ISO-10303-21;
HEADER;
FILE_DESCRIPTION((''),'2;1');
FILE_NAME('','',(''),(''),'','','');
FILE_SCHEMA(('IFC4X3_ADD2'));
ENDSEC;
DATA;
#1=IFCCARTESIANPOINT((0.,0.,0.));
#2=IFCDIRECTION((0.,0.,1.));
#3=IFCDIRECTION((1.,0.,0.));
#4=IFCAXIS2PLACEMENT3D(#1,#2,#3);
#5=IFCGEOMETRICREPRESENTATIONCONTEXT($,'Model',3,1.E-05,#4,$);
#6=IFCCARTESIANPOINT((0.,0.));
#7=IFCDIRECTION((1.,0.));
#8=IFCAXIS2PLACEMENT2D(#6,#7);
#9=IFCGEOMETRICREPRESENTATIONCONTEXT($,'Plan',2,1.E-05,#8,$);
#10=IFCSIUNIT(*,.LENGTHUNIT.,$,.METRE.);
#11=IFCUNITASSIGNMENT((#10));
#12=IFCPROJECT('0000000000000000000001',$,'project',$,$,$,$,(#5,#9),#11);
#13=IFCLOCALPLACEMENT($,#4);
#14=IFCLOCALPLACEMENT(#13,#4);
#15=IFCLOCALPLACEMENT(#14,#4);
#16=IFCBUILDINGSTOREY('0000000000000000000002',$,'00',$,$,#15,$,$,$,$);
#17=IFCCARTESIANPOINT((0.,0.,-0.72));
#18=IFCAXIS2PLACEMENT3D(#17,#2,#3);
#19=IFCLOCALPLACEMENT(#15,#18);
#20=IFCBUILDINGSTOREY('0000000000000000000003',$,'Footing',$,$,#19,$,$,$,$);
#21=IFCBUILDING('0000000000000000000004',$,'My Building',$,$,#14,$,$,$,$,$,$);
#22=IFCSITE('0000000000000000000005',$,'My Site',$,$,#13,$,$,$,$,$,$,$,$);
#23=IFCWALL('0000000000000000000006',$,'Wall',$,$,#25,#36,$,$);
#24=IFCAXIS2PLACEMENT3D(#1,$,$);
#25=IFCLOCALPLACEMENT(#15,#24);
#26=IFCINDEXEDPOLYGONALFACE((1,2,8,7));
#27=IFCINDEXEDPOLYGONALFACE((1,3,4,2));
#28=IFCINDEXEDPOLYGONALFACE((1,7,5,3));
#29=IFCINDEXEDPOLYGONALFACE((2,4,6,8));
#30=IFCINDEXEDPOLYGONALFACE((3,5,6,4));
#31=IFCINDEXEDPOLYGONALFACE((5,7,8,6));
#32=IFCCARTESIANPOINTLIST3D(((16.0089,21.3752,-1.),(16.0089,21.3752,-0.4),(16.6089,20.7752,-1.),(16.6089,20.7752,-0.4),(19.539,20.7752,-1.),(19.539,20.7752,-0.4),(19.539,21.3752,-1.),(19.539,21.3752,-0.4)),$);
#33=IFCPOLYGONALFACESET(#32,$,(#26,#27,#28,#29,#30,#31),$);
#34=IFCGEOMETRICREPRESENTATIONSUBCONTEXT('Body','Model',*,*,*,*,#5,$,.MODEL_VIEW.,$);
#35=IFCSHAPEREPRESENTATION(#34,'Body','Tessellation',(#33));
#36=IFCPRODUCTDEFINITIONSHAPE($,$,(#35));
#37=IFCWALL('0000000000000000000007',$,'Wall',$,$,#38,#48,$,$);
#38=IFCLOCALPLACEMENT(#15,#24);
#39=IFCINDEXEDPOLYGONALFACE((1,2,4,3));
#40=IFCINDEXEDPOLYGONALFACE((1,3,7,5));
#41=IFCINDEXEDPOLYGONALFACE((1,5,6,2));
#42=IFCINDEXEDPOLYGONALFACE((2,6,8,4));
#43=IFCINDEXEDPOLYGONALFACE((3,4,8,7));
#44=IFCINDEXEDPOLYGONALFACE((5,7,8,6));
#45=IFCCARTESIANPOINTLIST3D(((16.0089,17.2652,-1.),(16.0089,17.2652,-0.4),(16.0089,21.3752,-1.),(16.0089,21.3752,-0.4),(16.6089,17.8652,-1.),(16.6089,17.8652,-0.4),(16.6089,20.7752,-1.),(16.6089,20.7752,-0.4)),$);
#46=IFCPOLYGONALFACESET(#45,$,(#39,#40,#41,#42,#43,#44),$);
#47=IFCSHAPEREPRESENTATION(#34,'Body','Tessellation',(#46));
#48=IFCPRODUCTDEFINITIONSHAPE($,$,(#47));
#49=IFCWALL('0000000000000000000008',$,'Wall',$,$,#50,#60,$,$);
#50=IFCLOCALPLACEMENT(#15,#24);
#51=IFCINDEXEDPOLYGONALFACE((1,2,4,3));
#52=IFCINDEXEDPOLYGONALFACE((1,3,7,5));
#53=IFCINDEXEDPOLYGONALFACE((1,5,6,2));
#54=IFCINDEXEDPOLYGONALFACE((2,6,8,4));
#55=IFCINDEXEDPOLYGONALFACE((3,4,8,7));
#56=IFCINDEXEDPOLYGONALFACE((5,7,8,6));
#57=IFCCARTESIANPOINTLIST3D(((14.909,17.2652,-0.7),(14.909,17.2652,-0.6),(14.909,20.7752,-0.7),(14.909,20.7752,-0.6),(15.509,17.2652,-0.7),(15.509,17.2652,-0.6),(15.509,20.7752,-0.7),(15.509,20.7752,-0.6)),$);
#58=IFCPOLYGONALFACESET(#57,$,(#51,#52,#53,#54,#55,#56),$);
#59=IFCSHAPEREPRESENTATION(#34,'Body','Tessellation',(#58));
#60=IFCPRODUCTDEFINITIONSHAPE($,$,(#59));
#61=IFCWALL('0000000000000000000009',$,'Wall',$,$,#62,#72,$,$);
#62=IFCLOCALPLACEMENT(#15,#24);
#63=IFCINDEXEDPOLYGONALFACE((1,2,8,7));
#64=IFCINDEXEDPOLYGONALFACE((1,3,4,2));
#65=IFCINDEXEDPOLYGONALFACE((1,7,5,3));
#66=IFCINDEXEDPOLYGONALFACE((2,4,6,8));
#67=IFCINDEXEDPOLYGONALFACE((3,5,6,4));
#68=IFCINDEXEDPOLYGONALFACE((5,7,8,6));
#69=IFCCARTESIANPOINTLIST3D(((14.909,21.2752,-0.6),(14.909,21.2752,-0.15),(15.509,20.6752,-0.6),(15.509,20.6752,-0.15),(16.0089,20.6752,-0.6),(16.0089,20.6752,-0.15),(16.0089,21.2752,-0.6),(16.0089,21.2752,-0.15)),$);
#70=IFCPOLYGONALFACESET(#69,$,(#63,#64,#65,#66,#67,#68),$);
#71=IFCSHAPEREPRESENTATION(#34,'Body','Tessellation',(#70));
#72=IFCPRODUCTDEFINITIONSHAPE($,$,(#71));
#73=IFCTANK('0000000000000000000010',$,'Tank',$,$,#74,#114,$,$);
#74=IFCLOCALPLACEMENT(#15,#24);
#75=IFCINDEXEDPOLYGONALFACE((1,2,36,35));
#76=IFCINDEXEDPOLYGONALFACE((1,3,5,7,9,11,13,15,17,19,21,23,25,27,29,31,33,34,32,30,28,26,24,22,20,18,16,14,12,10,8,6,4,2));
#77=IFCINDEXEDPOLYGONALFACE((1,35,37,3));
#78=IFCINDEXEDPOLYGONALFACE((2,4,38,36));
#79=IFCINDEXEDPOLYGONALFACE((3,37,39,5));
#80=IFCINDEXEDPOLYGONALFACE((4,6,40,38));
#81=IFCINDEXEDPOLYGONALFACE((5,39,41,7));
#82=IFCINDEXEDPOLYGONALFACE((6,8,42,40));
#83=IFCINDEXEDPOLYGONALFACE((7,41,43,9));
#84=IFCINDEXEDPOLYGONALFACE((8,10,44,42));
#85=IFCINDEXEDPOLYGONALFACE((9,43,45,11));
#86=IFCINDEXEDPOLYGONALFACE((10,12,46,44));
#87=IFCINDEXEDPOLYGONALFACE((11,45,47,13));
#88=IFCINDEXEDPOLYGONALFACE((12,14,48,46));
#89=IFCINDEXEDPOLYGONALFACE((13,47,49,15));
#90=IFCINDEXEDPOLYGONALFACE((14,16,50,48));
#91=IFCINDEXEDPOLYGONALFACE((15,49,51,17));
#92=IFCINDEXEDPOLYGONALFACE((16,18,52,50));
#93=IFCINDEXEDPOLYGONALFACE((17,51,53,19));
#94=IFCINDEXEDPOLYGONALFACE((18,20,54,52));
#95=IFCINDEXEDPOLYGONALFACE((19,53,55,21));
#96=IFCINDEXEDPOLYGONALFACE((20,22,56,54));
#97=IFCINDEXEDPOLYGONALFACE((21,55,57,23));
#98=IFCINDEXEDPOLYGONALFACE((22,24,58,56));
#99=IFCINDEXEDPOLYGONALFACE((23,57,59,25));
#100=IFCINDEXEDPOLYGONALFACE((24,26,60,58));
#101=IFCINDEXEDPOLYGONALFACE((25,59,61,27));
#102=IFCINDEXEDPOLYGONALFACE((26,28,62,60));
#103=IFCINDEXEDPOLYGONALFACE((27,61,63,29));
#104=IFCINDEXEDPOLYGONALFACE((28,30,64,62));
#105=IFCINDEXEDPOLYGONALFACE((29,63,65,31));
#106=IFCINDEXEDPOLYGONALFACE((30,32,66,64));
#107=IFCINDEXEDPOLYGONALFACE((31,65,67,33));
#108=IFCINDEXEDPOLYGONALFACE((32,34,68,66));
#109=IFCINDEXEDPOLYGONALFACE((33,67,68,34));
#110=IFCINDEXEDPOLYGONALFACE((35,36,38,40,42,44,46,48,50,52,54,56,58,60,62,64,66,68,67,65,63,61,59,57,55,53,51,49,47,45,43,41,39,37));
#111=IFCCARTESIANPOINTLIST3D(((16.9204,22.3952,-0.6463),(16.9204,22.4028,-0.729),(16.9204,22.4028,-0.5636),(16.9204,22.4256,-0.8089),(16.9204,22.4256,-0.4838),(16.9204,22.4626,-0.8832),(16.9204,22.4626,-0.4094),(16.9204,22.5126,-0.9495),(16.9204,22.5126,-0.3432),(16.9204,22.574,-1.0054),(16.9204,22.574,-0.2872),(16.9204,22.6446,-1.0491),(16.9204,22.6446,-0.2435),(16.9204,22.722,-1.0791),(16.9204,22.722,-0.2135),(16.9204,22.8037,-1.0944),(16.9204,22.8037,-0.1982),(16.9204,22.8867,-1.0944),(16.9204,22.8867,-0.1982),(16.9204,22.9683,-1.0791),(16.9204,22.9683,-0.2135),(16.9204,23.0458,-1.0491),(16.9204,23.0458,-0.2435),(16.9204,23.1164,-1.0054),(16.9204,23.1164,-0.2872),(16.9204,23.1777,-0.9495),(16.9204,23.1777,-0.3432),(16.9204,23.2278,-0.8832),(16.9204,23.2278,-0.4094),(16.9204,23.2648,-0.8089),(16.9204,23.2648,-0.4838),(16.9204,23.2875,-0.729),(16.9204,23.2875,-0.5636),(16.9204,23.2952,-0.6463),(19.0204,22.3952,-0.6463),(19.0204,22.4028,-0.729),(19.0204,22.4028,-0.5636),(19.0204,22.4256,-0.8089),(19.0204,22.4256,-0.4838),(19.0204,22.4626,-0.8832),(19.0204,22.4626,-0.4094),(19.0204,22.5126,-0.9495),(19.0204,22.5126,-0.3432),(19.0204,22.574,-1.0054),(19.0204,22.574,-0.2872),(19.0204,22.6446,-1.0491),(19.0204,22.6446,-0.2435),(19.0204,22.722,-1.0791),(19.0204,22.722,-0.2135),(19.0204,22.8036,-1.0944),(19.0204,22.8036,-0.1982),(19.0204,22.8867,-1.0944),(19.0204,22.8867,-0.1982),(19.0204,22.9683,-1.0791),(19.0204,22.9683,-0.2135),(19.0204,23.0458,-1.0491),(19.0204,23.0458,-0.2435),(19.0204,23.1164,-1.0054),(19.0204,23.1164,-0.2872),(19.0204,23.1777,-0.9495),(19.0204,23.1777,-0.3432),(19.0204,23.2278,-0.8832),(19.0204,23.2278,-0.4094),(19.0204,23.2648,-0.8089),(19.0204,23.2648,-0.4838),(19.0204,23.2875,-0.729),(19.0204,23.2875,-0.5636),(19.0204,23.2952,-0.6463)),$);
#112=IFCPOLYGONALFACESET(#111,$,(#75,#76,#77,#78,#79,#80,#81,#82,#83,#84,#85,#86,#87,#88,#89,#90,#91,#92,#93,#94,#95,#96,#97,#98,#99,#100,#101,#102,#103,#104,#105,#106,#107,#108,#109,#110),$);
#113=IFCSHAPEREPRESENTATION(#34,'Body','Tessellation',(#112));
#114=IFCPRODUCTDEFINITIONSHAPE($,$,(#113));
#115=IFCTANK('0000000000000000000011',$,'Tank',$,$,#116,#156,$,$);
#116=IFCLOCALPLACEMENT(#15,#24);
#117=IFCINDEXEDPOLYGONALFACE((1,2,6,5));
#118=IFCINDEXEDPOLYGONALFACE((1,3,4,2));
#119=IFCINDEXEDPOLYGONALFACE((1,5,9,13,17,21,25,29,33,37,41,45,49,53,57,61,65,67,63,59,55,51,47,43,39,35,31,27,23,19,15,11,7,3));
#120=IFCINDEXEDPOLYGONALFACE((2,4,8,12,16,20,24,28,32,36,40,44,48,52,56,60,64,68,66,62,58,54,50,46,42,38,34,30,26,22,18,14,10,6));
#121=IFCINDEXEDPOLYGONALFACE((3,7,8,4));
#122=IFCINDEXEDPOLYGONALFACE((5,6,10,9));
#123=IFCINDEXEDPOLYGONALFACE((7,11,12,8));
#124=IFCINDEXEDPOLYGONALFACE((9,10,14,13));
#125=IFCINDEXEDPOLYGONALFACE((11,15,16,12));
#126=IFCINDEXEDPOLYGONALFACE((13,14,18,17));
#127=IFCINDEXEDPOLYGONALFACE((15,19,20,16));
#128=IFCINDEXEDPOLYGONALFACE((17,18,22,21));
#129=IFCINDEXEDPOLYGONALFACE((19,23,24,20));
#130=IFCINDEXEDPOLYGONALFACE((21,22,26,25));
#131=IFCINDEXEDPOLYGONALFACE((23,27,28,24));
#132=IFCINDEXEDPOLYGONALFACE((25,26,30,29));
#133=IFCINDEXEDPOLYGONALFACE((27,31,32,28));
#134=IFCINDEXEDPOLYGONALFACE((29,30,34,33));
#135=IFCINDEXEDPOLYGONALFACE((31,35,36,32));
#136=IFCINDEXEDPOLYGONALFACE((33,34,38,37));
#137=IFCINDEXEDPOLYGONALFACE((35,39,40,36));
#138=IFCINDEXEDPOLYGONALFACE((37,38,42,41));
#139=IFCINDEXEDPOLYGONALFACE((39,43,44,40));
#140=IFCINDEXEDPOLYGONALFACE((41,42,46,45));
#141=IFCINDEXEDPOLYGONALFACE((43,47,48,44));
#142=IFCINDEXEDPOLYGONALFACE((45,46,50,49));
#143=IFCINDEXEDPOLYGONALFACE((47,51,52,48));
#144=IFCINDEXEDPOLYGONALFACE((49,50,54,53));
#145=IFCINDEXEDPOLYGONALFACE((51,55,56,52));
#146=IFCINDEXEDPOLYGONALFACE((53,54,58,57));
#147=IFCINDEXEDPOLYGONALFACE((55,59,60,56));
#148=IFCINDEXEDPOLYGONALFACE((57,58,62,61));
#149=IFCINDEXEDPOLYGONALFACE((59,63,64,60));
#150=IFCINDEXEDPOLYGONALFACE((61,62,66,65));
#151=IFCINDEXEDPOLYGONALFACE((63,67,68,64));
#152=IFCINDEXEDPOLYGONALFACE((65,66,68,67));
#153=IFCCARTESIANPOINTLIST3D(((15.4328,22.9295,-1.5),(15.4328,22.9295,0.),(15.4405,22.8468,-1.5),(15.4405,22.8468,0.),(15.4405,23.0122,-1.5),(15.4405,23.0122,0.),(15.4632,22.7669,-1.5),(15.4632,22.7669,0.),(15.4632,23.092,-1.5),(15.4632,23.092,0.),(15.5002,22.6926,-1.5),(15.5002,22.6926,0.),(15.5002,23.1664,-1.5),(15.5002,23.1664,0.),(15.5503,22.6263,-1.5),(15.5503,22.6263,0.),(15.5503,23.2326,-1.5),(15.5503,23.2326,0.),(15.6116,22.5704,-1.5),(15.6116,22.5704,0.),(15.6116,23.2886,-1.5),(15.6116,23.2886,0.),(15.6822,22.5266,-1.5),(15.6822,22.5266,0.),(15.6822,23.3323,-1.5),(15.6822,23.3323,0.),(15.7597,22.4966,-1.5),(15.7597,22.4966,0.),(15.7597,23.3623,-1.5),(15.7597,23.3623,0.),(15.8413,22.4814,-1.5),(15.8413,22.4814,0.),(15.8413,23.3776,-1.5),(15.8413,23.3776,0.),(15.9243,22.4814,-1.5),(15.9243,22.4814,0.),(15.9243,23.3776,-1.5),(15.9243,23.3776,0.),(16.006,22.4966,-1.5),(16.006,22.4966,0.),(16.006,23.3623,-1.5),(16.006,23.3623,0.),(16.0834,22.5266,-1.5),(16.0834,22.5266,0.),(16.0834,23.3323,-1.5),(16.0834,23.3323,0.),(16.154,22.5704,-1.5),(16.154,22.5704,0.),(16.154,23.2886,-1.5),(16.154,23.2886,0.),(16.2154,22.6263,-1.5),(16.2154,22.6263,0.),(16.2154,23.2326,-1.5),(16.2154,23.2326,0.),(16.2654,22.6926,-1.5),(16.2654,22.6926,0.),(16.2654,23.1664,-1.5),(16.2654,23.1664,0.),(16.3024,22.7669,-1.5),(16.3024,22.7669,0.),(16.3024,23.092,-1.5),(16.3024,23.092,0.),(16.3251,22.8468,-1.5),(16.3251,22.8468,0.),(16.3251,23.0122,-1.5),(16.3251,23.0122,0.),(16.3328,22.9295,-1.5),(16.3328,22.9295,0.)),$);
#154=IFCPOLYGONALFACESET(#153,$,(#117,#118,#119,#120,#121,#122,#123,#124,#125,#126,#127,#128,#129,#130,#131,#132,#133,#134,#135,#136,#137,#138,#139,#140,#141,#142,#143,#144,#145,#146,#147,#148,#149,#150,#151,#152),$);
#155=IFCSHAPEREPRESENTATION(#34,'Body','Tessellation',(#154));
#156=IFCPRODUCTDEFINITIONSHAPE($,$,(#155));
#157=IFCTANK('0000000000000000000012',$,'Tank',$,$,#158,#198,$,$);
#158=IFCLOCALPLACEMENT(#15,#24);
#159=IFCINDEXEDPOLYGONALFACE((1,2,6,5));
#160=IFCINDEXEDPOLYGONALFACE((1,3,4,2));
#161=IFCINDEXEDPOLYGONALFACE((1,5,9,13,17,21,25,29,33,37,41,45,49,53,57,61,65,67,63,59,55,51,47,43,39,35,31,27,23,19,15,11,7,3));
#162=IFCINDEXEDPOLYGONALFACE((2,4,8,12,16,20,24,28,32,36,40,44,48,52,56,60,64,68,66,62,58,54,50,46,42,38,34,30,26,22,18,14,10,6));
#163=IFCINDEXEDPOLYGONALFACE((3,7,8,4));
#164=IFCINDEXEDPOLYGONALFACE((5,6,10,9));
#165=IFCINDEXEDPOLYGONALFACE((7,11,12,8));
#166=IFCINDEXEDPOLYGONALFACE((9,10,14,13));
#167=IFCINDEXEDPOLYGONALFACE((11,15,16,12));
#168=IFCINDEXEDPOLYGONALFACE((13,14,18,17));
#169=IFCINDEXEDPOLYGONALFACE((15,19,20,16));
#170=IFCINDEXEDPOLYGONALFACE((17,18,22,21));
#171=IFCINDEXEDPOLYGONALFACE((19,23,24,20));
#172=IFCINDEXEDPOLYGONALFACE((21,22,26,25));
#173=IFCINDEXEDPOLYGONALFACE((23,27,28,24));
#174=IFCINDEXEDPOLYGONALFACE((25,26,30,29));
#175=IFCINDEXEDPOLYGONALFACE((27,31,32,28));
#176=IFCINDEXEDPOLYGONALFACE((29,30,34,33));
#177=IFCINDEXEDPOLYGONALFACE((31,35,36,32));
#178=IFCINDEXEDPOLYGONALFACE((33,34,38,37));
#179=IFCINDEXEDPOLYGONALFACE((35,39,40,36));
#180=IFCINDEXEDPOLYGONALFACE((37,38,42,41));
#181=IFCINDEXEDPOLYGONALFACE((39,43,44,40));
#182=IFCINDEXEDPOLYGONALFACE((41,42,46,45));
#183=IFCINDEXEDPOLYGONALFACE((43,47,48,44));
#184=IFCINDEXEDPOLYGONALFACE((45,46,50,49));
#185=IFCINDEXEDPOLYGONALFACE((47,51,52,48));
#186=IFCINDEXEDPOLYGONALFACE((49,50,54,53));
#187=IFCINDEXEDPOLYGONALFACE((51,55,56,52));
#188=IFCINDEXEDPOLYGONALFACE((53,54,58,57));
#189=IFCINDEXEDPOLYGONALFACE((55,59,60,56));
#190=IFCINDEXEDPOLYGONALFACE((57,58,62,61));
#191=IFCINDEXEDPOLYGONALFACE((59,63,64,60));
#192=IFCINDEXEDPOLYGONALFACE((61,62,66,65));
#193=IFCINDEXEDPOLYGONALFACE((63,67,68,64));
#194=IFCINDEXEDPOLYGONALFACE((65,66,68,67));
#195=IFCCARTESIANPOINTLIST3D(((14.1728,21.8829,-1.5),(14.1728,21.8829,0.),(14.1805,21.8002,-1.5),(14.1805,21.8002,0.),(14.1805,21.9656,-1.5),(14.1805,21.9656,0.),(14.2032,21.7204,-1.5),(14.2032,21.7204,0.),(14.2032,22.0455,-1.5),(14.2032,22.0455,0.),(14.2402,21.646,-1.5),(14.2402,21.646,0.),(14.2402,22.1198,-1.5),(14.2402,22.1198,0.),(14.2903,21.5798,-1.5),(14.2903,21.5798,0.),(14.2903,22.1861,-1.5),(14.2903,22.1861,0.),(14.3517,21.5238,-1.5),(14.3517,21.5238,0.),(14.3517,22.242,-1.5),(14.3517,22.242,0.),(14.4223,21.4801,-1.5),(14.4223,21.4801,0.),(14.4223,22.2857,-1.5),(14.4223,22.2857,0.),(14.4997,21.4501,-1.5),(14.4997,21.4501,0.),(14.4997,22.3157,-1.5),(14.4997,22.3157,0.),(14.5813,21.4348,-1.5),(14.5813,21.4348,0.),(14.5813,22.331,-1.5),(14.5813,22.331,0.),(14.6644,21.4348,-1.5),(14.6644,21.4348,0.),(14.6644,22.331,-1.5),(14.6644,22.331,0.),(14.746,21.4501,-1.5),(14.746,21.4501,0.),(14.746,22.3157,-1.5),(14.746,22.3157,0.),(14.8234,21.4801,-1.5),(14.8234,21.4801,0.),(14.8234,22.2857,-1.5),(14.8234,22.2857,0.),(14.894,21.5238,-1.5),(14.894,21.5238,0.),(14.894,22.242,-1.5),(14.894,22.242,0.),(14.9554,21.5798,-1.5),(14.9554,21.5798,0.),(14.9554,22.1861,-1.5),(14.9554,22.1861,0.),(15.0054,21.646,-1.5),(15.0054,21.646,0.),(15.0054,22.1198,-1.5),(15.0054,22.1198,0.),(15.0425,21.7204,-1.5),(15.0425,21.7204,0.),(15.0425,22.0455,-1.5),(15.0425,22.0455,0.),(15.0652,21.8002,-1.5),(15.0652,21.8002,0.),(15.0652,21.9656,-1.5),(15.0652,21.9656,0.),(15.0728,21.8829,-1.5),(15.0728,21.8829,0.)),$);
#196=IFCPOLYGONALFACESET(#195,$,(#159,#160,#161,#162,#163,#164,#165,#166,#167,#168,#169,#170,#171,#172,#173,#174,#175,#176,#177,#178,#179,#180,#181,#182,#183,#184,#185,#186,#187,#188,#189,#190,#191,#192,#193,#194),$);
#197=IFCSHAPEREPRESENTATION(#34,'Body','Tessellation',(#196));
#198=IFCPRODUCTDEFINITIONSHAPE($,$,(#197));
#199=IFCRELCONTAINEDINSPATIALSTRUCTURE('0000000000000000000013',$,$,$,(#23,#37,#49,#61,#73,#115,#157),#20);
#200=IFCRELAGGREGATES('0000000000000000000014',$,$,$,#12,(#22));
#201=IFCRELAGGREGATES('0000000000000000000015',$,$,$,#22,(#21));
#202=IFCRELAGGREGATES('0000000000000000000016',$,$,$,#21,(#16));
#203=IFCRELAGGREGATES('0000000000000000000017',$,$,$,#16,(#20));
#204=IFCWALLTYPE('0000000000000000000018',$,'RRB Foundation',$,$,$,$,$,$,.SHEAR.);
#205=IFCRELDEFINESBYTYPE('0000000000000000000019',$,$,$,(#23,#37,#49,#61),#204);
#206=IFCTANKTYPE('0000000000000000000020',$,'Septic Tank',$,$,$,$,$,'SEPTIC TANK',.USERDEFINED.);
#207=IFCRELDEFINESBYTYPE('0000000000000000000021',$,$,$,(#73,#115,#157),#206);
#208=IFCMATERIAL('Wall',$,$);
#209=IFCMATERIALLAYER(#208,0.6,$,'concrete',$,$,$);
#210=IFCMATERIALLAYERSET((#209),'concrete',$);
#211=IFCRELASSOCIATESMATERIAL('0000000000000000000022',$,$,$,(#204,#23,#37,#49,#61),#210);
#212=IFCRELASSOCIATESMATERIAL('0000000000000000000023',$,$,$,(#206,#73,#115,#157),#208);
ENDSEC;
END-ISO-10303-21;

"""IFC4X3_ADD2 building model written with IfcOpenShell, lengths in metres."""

from ifc_helpers import new_model, si_unit, frame, origin_with_axes, origin_2d_with_axis, place, context, subcontext, project, spatial, line, indexed_curve, circle, outline, extrude, material, layer, layer_set, layer_usage, material_profile, profile_set, profile_usage, type_object, element, save


model = new_model("IFC4X3_ADD2")

# Units and contexts
model_context = context("Model", 3, precision=1e-05, world=origin_with_axes())
plan_context = context("Plan", 2, precision=1e-05, world=origin_2d_with_axis())
body_context_1 = subcontext(model_context, "Body", "Model", "MODEL_VIEW")
ifc_project = project(units=[si_unit("LENGTHUNIT", "METRE")], contexts=[model_context, plan_context])

# Site, building, storeys
site_placement = place(None, origin_with_axes())
site = spatial("IfcSite", under=ifc_project, at=site_placement, Name="My Site")
building_placement = place(site_placement, origin_with_axes())
building = spatial("IfcBuilding", under=site, at=building_placement, Name="My Building")
storey_1_placement = place(building_placement, origin_with_axes())
storey_1 = spatial("IfcBuildingStorey", under=building, at=storey_1_placement, Name="00")
storey_2_placement = place(storey_1_placement, frame((0.0, 0.0, -0.72), z_axis=(0.0, 0.0, 1.0), x_axis=(1.0, 0.0, 0.0)))
storey_2 = spatial("IfcBuildingStorey", under=storey_1, at=storey_2_placement, Name="Footing")

# Walls
ifc_material_1 = material(Name="Wall")
ifc_layer_1 = layer(ifc_material_1, 0.6, Name="concrete")
ifc_layer_set_1 = layer_set([ifc_layer_1], Name="concrete")
wall_type_1 = type_object("IfcWallType", Name="RRB Foundation", PredefinedType="SHEAR", material=ifc_layer_set_1)
ifc_layer_usage_1 = layer_usage(ifc_layer_set_1, "AXIS2", "POSITIVE", 0.0)
wall_1_placement = place(storey_2_placement, frame((16.6089, 20.7752, -0.28), z_axis=(0.0, 0.0, 1.0), x_axis=(1.0, 0.0, 0.0)))
element("IfcWall", 1, at=wall_1_placement, inside=storey_2, type_object=wall_type_1, material=ifc_layer_usage_1, Name="Wall", context=body_context_1, shape_type="SweptSolid", body=[
    extrude(outline(indexed_curve([(0.0, 0.0), (-0.6, 0.6), (2.93, 0.6), (2.93, 0.0)], segments=[line(1, 2, 3, 4, 1)])), origin_with_axes(), (0.0, 0.0, 1.0), 0.6),
])
ifc_layer_usage_2 = layer_usage(ifc_layer_set_1, "AXIS2", "POSITIVE", 0.0)
wall_2_placement = place(storey_2_placement, frame((16.6089, 17.2652, -0.28), z_axis=(0.0, 0.0, 1.0), x_axis=(0.000001, 1.0, 0.0)))
element("IfcWall", 2, at=wall_2_placement, inside=storey_2, type_object=wall_type_1, material=ifc_layer_usage_2, Name="Wall", context=body_context_1, shape_type="SweptSolid", body=[
    extrude(outline(indexed_curve([(0.6, 0.0), (0.0, 0.6), (4.11, 0.6), (3.51, 0.0)], segments=[line(1, 2, 3, 4, 1)])), origin_with_axes(), (0.0, 0.0, 1.0), 0.6),
])
ifc_layer_usage_3 = layer_usage(ifc_layer_set_1, "AXIS2", "POSITIVE", 0.0)
wall_3_placement = place(storey_2_placement, frame((15.509, 17.2652, 0.02), z_axis=(0.0, 0.0, 1.0), x_axis=(0.000001, 1.0, 0.0)))
element("IfcWall", 3, at=wall_3_placement, inside=storey_2, type_object=wall_type_1, material=ifc_layer_usage_3, Name="Wall", context=body_context_1, shape_type="SweptSolid", body=[
    extrude(outline(indexed_curve([(0.0, 0.0), (0.0, 0.6), (3.51, 0.6), (3.51, 0.0)], segments=[line(1, 2, 3, 4, 1)])), origin_with_axes(), (0.0, 0.0, 1.0), 0.1),
])
ifc_layer_usage_4 = layer_usage(ifc_layer_set_1, "AXIS2", "POSITIVE", 0.0)
wall_4_placement = place(storey_2_placement, frame((15.509, 20.6752, 0.12), z_axis=(0.0, 0.0, 1.0), x_axis=(1.0, 0.0, 0.0)))
element("IfcWall", 4, at=wall_4_placement, inside=storey_2, type_object=wall_type_1, material=ifc_layer_usage_4, Name="Wall", context=body_context_1, shape_type="SweptSolid", body=[
    extrude(outline(indexed_curve([(0.0, 0.0), (-0.6, 0.6), (0.4999, 0.6), (0.4999, 0.0)], segments=[line(1, 2, 3, 4, 1)])), origin_with_axes(), (0.0, 0.0, 1.0), 0.45),
])

# Tanks
ifc_material_profile_1 = material_profile(ifc_material_1, circle(Radius=0.45))
ifc_profile_set_1 = profile_set([ifc_material_profile_1])
ifc_profile_usage_1 = profile_usage(ifc_profile_set_1, cardinal=5)
tank_type = type_object("IfcTankType", Name="Septic Tank", ElementType="SEPTIC TANK", PredefinedType="USERDEFINED", material=ifc_profile_set_1)
tank_1_placement = place(storey_2_placement, frame((16.9204, 22.8452, 0.0737), z_axis=(1.0, 0.0, 0.0), x_axis=(0.0, 1.0, 0.0)))
element("IfcTank", 5, at=tank_1_placement, inside=storey_2, type_object=tank_type, material=ifc_profile_usage_1, Name="Tank", context=body_context_1, shape_type="SweptSolid", body=[
    extrude(circle(Radius=0.45), origin_with_axes(), (0.0, 0.0, 1.0), 2.1),
])
ifc_profile_usage_2 = profile_usage(ifc_profile_set_1, cardinal=5)
tank_2_placement = place(storey_2_placement, frame((15.8828, 22.9295, -0.78), z_axis=(0.0, 0.0, 1.0), x_axis=(-1.0, 0.0, 0.0)))
element("IfcTank", 6, at=tank_2_placement, inside=storey_2, type_object=tank_type, material=ifc_profile_usage_2, Name="Tank", context=body_context_1, shape_type="SweptSolid", body=[
    extrude(circle(Radius=0.45), origin_with_axes(), (0.0, 0.0, 1.0), 1.5),
])
ifc_profile_usage_3 = profile_usage(ifc_profile_set_1, cardinal=5)
tank_3_placement = place(storey_2_placement, frame((14.6228, 21.8829, -0.78), z_axis=(0.0, 0.0, 1.0), x_axis=(-1.0, 0.0, 0.0)))
element("IfcTank", 7, at=tank_3_placement, inside=storey_2, type_object=tank_type, material=ifc_profile_usage_3, Name="Tank", context=body_context_1, shape_type="SweptSolid", body=[
    extrude(circle(Radius=0.45), origin_with_axes(), (0.0, 0.0, 1.0), 1.5),
])

save(model, "model.ifc")
